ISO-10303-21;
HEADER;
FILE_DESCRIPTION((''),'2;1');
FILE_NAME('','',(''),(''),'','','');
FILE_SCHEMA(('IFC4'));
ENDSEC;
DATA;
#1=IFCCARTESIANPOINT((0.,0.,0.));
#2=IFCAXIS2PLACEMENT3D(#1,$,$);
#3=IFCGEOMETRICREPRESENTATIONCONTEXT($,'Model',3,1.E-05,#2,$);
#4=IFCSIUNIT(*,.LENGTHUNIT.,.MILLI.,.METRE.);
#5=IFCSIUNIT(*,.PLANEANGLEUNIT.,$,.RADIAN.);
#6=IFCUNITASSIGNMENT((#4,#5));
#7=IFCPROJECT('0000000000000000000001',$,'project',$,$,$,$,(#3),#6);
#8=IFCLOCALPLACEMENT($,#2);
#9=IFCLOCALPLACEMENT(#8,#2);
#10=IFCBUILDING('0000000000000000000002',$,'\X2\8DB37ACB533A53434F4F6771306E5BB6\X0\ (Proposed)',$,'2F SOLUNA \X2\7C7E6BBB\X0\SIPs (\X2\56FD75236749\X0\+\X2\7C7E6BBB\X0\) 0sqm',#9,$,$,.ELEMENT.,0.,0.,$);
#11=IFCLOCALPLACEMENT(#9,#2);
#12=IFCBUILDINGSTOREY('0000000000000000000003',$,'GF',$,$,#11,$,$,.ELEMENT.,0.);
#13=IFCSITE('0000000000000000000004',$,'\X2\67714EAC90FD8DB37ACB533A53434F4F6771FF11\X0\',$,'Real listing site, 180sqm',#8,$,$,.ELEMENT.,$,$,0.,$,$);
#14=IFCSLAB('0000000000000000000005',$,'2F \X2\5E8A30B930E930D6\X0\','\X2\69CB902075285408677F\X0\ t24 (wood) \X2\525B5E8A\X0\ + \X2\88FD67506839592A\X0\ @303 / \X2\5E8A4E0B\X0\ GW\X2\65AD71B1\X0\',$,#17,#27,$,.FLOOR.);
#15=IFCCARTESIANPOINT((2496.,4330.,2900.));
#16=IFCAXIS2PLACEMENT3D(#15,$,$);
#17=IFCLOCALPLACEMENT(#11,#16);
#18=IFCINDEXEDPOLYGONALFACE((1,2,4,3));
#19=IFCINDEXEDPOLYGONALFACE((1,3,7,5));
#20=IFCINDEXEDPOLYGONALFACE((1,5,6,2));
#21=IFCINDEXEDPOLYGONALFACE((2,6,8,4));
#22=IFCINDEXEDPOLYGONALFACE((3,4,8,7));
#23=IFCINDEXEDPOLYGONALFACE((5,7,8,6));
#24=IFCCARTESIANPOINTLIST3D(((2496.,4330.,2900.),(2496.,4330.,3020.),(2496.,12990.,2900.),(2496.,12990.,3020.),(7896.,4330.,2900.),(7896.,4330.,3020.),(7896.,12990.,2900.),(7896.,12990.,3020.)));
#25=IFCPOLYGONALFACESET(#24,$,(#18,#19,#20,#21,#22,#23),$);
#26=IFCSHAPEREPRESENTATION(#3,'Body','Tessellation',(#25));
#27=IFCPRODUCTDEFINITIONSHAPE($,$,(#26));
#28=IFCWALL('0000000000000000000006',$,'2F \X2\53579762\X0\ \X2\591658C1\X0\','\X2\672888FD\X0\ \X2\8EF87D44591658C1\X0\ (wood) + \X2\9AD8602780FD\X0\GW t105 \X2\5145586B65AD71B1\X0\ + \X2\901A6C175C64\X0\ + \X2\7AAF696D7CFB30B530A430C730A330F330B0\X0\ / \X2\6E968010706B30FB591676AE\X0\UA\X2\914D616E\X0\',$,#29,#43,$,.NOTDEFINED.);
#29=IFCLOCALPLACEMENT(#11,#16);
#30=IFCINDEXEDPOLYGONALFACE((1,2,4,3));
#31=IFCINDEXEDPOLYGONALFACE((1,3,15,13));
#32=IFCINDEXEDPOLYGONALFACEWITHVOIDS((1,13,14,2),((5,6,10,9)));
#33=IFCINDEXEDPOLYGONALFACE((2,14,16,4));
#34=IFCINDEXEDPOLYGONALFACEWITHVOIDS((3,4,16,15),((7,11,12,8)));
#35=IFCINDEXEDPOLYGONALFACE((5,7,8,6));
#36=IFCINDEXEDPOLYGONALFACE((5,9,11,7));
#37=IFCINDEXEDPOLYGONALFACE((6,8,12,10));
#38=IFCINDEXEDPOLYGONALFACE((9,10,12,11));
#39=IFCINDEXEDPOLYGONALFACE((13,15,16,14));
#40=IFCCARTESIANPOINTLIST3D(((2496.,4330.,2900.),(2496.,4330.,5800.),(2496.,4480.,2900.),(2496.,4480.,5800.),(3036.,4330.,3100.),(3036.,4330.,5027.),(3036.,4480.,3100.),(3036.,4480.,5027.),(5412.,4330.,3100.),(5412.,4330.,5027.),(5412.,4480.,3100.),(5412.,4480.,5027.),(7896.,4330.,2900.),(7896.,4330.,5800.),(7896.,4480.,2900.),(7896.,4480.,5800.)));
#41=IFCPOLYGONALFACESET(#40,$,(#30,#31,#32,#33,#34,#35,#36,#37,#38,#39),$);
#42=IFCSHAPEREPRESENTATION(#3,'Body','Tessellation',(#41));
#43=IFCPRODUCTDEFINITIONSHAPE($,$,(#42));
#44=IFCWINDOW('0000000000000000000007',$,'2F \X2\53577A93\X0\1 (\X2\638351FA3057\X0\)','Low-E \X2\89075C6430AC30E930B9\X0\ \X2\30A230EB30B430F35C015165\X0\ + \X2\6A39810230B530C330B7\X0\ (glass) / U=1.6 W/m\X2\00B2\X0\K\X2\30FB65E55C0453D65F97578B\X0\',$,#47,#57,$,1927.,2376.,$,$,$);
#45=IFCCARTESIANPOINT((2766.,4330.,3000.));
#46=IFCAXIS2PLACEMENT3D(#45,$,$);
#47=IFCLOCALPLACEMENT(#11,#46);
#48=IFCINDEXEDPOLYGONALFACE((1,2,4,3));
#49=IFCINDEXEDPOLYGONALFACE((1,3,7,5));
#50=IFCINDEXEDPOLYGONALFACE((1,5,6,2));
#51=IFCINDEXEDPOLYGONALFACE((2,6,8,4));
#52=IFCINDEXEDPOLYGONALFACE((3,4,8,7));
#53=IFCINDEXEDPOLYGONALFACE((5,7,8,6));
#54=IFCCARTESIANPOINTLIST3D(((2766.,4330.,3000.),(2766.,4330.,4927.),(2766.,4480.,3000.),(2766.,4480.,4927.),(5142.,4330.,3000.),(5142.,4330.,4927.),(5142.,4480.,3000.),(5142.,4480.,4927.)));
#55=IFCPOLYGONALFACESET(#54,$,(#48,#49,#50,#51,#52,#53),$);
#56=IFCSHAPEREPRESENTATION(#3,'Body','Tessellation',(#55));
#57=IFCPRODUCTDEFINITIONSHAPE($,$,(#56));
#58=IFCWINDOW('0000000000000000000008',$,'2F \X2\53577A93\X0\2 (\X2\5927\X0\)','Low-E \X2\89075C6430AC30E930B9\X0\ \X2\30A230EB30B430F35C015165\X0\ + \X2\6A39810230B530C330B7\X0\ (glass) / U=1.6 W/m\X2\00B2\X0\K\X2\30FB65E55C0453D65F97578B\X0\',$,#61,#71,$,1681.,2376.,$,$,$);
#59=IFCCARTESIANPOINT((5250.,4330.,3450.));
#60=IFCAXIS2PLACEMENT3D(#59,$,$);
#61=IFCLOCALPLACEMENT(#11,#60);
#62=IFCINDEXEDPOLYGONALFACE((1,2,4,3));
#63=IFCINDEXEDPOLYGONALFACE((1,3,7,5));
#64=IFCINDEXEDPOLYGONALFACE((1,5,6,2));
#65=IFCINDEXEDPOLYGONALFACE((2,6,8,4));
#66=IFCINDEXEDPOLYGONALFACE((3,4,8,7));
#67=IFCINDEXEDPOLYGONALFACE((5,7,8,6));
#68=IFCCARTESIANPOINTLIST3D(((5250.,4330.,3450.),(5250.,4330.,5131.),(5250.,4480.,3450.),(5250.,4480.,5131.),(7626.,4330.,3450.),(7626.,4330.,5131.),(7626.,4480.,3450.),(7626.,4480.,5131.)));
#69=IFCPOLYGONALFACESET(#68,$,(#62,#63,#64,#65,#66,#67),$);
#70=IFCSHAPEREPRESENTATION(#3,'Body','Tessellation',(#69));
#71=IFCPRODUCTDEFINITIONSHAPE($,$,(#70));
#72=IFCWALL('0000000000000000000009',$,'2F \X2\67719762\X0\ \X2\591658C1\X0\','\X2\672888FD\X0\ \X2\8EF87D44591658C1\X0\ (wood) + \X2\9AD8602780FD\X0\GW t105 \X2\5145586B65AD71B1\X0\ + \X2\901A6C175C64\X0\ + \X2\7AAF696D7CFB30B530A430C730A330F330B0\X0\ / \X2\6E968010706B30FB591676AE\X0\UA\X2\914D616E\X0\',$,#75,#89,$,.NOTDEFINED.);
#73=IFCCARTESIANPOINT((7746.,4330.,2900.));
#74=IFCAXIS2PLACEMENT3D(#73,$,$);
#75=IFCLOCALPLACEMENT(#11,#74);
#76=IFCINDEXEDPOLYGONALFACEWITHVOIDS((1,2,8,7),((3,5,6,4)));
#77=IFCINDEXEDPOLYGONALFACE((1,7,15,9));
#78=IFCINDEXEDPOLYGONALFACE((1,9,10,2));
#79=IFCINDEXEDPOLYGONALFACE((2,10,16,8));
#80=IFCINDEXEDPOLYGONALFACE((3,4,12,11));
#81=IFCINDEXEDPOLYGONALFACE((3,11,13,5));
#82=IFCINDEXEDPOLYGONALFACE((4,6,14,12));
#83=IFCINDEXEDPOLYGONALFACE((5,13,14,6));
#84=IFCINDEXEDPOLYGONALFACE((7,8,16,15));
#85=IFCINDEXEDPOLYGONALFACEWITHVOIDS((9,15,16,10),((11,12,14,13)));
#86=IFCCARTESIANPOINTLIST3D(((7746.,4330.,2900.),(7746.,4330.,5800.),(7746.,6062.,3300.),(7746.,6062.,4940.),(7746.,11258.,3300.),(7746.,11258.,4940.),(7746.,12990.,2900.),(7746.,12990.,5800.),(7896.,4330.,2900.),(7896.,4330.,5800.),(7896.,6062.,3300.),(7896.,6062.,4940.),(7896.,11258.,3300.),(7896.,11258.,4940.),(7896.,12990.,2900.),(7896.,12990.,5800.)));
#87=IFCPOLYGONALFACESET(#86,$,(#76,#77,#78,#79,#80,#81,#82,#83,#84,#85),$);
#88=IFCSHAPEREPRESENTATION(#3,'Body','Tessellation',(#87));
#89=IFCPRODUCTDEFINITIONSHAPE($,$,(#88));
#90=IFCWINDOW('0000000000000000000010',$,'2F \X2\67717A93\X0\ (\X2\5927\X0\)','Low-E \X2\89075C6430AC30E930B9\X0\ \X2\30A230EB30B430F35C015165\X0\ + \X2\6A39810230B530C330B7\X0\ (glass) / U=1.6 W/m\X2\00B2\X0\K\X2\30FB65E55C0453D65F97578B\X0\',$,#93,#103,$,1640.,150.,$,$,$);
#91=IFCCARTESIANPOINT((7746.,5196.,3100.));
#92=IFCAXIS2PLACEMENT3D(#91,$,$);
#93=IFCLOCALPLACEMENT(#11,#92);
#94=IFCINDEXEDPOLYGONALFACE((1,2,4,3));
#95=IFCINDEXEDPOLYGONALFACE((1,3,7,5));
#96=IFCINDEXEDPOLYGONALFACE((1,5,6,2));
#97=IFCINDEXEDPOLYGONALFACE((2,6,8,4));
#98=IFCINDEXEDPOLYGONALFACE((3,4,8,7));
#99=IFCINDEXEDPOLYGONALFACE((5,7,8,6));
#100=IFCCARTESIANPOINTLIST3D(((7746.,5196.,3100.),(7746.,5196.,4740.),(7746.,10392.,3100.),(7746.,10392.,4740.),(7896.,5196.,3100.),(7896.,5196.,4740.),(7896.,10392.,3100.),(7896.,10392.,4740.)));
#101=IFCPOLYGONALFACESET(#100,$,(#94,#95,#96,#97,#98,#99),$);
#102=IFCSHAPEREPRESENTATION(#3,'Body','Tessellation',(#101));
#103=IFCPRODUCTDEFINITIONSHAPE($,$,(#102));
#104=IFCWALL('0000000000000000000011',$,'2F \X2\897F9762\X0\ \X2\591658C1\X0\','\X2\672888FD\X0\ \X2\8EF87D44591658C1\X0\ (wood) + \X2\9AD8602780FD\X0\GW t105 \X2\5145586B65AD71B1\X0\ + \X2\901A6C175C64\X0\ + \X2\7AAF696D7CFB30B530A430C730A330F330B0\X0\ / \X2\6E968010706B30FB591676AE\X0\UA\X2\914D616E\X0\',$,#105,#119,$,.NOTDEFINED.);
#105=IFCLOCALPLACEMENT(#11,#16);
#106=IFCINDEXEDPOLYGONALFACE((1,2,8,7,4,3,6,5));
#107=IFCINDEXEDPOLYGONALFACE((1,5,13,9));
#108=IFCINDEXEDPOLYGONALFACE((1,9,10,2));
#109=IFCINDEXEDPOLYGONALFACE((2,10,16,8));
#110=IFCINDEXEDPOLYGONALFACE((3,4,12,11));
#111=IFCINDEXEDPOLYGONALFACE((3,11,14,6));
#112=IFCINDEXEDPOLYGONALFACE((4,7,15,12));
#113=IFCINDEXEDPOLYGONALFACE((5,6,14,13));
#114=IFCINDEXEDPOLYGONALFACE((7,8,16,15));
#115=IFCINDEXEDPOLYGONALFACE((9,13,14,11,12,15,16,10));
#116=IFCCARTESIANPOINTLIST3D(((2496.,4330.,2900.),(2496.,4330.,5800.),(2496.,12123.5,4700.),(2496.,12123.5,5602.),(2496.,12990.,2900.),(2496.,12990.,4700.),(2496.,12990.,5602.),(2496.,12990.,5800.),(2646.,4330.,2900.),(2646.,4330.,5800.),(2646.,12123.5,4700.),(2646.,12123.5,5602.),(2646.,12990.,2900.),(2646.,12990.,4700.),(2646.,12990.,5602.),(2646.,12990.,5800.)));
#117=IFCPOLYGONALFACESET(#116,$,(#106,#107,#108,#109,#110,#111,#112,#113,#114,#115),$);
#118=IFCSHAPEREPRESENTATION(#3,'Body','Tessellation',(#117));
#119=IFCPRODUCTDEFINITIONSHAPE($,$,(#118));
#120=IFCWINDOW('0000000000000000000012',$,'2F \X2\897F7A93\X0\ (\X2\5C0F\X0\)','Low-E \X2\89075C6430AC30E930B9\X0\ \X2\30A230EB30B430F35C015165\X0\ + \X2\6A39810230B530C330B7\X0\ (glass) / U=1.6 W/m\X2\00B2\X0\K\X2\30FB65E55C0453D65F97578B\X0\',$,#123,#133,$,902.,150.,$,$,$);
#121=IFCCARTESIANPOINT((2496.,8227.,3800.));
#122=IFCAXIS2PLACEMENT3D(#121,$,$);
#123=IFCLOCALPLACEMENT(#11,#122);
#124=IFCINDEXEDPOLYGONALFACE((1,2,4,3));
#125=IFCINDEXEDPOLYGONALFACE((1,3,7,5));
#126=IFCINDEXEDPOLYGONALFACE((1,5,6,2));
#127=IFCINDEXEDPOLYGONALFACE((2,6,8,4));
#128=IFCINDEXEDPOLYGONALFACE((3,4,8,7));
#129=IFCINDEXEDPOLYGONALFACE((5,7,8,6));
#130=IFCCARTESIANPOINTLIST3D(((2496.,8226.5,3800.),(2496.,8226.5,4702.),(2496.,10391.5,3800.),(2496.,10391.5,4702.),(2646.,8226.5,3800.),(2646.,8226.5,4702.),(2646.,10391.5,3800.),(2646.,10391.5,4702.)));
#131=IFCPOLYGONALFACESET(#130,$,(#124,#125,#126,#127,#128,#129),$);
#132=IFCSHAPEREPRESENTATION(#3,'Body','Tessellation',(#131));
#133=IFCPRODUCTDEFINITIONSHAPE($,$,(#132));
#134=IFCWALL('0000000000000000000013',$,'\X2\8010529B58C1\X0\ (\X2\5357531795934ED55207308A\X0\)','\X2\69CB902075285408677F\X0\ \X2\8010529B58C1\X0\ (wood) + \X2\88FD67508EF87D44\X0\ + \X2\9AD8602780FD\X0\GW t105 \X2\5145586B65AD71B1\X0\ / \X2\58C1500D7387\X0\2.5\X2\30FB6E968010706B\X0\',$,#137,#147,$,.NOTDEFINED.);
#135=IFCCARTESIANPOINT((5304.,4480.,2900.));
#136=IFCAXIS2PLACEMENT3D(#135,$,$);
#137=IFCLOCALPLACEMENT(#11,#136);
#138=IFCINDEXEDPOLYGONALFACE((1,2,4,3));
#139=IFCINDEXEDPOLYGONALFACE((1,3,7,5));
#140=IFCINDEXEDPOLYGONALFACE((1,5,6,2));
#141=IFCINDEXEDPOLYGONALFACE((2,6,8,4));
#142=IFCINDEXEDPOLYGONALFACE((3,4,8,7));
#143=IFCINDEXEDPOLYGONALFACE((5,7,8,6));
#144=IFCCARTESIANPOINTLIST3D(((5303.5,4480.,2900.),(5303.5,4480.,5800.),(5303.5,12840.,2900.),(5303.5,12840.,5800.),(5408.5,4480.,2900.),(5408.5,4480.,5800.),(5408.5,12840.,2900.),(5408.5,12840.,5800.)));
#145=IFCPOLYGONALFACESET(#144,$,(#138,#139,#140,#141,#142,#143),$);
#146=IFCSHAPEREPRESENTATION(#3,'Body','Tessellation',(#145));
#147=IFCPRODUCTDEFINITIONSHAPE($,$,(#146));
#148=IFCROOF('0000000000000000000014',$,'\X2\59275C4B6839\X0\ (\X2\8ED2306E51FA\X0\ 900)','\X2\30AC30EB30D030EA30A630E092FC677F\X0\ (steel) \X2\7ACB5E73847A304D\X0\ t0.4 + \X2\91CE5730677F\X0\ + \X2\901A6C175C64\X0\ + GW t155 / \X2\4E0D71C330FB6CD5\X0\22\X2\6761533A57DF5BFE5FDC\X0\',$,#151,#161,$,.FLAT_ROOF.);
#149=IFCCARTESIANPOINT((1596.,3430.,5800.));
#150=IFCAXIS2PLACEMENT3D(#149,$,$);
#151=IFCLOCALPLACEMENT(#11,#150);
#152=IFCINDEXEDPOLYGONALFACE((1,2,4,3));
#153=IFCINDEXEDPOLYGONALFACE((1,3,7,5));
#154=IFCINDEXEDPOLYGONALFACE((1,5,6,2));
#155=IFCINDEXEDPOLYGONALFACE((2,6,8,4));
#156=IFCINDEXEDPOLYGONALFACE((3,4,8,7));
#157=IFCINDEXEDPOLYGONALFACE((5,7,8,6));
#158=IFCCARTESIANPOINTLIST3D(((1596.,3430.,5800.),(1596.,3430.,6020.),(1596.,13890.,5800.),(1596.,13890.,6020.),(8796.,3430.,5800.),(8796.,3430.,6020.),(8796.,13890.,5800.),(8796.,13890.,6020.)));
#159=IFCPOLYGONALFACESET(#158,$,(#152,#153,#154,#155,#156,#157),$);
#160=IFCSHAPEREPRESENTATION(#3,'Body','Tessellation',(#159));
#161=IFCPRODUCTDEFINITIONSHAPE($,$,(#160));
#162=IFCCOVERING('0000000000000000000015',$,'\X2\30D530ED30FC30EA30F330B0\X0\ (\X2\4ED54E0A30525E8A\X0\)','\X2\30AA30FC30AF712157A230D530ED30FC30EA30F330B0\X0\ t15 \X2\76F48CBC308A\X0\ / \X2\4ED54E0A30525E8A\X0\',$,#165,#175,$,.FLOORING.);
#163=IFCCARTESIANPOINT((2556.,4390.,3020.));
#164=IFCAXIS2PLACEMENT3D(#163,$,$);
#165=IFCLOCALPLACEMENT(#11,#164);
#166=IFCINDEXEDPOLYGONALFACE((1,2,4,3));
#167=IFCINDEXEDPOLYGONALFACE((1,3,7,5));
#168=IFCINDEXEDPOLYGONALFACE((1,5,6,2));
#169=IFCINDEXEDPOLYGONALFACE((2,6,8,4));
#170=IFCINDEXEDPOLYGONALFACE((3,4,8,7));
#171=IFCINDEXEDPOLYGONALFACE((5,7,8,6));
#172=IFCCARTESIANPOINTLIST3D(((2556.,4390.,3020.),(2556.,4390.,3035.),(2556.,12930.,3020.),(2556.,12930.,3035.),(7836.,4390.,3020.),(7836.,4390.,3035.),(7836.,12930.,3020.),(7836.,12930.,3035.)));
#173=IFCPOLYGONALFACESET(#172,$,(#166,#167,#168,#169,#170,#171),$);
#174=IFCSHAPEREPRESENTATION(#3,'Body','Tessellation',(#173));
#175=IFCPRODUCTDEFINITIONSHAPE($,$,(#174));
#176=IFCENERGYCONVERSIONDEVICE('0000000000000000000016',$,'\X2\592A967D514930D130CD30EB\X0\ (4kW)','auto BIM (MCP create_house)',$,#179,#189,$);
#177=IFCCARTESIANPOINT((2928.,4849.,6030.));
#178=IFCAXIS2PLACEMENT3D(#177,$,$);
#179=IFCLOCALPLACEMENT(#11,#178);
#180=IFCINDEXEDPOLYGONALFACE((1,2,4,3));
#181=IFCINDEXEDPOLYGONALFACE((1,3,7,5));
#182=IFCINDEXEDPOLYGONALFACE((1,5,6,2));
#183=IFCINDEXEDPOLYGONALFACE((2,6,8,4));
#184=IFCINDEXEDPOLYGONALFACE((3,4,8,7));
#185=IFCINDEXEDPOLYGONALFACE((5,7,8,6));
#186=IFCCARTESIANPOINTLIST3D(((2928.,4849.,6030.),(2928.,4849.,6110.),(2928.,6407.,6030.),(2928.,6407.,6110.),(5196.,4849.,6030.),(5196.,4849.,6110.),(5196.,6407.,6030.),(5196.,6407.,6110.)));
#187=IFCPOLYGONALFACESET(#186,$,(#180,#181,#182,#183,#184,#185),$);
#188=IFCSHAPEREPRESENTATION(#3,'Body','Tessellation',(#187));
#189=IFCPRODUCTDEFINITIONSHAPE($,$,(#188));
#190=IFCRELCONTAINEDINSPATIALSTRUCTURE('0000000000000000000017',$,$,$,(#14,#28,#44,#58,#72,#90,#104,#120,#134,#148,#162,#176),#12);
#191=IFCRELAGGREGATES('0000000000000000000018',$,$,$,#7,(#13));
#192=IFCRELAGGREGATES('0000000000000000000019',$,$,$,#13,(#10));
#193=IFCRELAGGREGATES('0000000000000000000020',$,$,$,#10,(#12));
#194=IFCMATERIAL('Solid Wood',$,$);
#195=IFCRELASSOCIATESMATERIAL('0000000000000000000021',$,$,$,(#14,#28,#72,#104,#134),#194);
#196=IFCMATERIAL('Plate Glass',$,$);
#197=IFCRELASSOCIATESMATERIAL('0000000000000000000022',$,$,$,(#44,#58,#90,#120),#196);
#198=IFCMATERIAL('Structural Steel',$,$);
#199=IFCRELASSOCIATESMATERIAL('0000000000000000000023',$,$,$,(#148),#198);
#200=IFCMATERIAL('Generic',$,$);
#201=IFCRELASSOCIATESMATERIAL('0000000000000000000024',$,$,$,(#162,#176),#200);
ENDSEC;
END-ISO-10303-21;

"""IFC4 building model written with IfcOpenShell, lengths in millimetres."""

from ifc_helpers import new_model, si_unit, frame, frame_2d, origin, place, context, project, spatial, rectangle, extrude, material, element, fill, save


model = new_model("IFC4")

# Units and contexts
model_context = context("Model", 3, precision=1e-05, world=origin())
ifc_project = project(units=[si_unit("LENGTHUNIT", "METRE", prefix="MILLI"), si_unit("PLANEANGLEUNIT", "RADIAN")], contexts=[model_context])

# Site, building, storey
site_placement = place(None, origin())
site = spatial("IfcSite", under=ifc_project, at=site_placement, Name="東京都足立区千住東１", ObjectType="Real listing site, 180sqm", CompositionType="ELEMENT", RefElevation=0.0)
building_placement = place(site_placement, origin())
building = spatial("IfcBuilding", under=site, at=building_placement, Name="足立区千住東の家 (Proposed)", ObjectType="2F SOLUNA 籾殻SIPs (国産杉+籾殻) 0sqm", CompositionType="ELEMENT", ElevationOfRefHeight=0.0, ElevationOfTerrain=0.0)
storey_placement = place(building_placement, origin())
storey = spatial("IfcBuildingStorey", under=building, at=storey_placement, Name="GF", CompositionType="ELEMENT", Elevation=0.0)

# Slab
ifc_material_1 = material(Name="Solid Wood")
slab_placement = place(storey_placement, frame((2496.0, 4330.0, 2900.0)))
element("IfcSlab", 1, at=slab_placement, inside=storey, material=ifc_material_1, Name="2F 床スラブ", Description="構造用合板 t24 (wood) 剛床 + 製材根太 @303 / 床下 GW断熱", PredefinedType="FLOOR", context=model_context, shape_type="SweptSolid", body=[
    extrude(rectangle(XDim=5400.0, YDim=8660.0, at=frame_2d((2700.0, 4330.0))), frame((2496.0, 4330.0, 2900.0)), (0.0, 0.0, 1.0), 120.0),
])

# Wall, openings, windows
wall_1_placement = place(storey_placement, frame((2496.0, 4330.0, 2900.0)))
wall_1 = element("IfcWall", 2, at=wall_1_placement, inside=storey, material=ifc_material_1, Name="2F 南面 外壁", Description="木製 軸組外壁 (wood) + 高性能GW t105 充填断熱 + 通気層 + 窯業系サイディング / 準耐火・外皮UA配慮", PredefinedType="NOTDEFINED", context=model_context, shape_type="SweptSolid", body=[
    extrude(rectangle(XDim=5400.0, YDim=150.0, at=frame_2d((2700.0, 75.0))), frame((2496.0, 4330.0, 2900.0)), (0.0, 0.0, 1.0), 2900.0),
])
opening_1_placement = place(storey_placement, frame((2766.0, 4330.0, 3000.0)))
opening_1 = element("IfcOpeningElement", 3, at=opening_1_placement, cuts=wall_1, PredefinedType="NOTDEFINED", context=model_context, shape_type="SweptSolid", body=[
    extrude(rectangle(XDim=2376.0, YDim=150.0, at=frame_2d((1188.0, 75.0))), frame((2766.0, 4330.0, 3000.0)), (0.0, 0.0, 1.0), 1927.0),
])
opening_2_placement = place(storey_placement, frame((5250.0, 4330.0, 3450.0)))
opening_2 = element("IfcOpeningElement", 4, at=opening_2_placement, cuts=wall_1, PredefinedType="NOTDEFINED", context=model_context, shape_type="SweptSolid", body=[
    extrude(rectangle(XDim=2376.0, YDim=150.0, at=frame_2d((1188.0, 75.0))), frame((5250.0, 4330.0, 3450.0)), (0.0, 0.0, 1.0), 1681.0),
])
ifc_material_2 = material(Name="Plate Glass")
window_1_placement = place(storey_placement, frame((2766.0, 4330.0, 3000.0)))
window_1 = element("IfcWindow", 5, at=window_1_placement, inside=storey, material=ifc_material_2, Name="2F 南窓1 (掃出し)", Description="Low-E 複層ガラス アルゴン封入 + 樹脂サッシ (glass) / U=1.6 W/m²K・日射取得型", OverallHeight=1927.0, OverallWidth=2376.0, context=model_context, shape_type="SweptSolid", body=[
    extrude(rectangle(XDim=2376.0, YDim=150.0, at=frame_2d((1188.0, 75.0))), frame((2766.0, 4330.0, 3000.0)), (0.0, 0.0, 1.0), 1927.0),
])
fill(opening_1, window_1)
window_2_placement = place(storey_placement, frame((5250.0, 4330.0, 3450.0)))
window_2 = element("IfcWindow", 6, at=window_2_placement, inside=storey, material=ifc_material_2, Name="2F 南窓2 (大)", Description="Low-E 複層ガラス アルゴン封入 + 樹脂サッシ (glass) / U=1.6 W/m²K・日射取得型", OverallHeight=1681.0, OverallWidth=2376.0, context=model_context, shape_type="SweptSolid", body=[
    extrude(rectangle(XDim=2376.0, YDim=150.0, at=frame_2d((1188.0, 75.0))), frame((5250.0, 4330.0, 3450.0)), (0.0, 0.0, 1.0), 1681.0),
])
fill(opening_2, window_2)

# Walls, openings, windows
wall_2_placement = place(storey_placement, frame((7746.0, 4330.0, 2900.0)))
wall_2 = element("IfcWall", 7, at=wall_2_placement, inside=storey, material=ifc_material_1, Name="2F 東面 外壁", Description="木製 軸組外壁 (wood) + 高性能GW t105 充填断熱 + 通気層 + 窯業系サイディング / 準耐火・外皮UA配慮", PredefinedType="NOTDEFINED", context=model_context, shape_type="SweptSolid", body=[
    extrude(rectangle(XDim=150.0, YDim=8660.0, at=frame_2d((75.0, 4330.0))), frame((7746.0, 4330.0, 2900.0)), (0.0, 0.0, 1.0), 2900.0),
])
opening_3_placement = place(storey_placement, frame((7746.0, 5196.0, 3100.0)))
opening_3 = element("IfcOpeningElement", 8, at=opening_3_placement, cuts=wall_2, PredefinedType="NOTDEFINED", context=model_context, shape_type="SweptSolid", body=[
    extrude(rectangle(XDim=150.0, YDim=5196.0, at=frame_2d((75.0, 2598.0))), frame((7746.0, 5196.0, 3100.0)), (0.0, 0.0, 1.0), 1640.0),
])
window_3_placement = place(storey_placement, frame((7746.0, 5196.0, 3100.0)))
window_3 = element("IfcWindow", 9, at=window_3_placement, inside=storey, material=ifc_material_2, Name="2F 東窓 (大)", Description="Low-E 複層ガラス アルゴン封入 + 樹脂サッシ (glass) / U=1.6 W/m²K・日射取得型", OverallHeight=1640.0, OverallWidth=150.0, context=model_context, shape_type="SweptSolid", body=[
    extrude(rectangle(XDim=150.0, YDim=5196.0, at=frame_2d((75.0, 2598.0))), frame((7746.0, 5196.0, 3100.0)), (0.0, 0.0, 1.0), 1640.0),
])
fill(opening_3, window_3)
wall_3_placement = place(storey_placement, frame((2496.0, 4330.0, 2900.0)))
wall_3 = element("IfcWall", 10, at=wall_3_placement, inside=storey, material=ifc_material_1, Name="2F 西面 外壁", Description="木製 軸組外壁 (wood) + 高性能GW t105 充填断熱 + 通気層 + 窯業系サイディング / 準耐火・外皮UA配慮", PredefinedType="NOTDEFINED", context=model_context, shape_type="SweptSolid", body=[
    extrude(rectangle(XDim=150.0, YDim=8660.0, at=frame_2d((75.0, 4330.0))), frame((2496.0, 4330.0, 2900.0)), (0.0, 0.0, 1.0), 2900.0),
])
opening_4_placement = place(storey_placement, frame((2496.0, 8227.0, 3800.0)))
opening_4 = element("IfcOpeningElement", 11, at=opening_4_placement, cuts=wall_3, PredefinedType="NOTDEFINED", context=model_context, shape_type="SweptSolid", body=[
    extrude(rectangle(XDim=150.0, YDim=2165.0, at=frame_2d((75.0, 1082.0))), frame((2496.0, 8227.0, 3800.0)), (0.0, 0.0, 1.0), 902.0),
])
window_4_placement = place(storey_placement, frame((2496.0, 8227.0, 3800.0)))
window_4 = element("IfcWindow", 12, at=window_4_placement, inside=storey, material=ifc_material_2, Name="2F 西窓 (小)", Description="Low-E 複層ガラス アルゴン封入 + 樹脂サッシ (glass) / U=1.6 W/m²K・日射取得型", OverallHeight=902.0, OverallWidth=150.0, context=model_context, shape_type="SweptSolid", body=[
    extrude(rectangle(XDim=150.0, YDim=2165.0, at=frame_2d((75.0, 1082.0))), frame((2496.0, 8227.0, 3800.0)), (0.0, 0.0, 1.0), 902.0),
])
fill(opening_4, window_4)

# Wall
wall_4_placement = place(storey_placement, frame((5304.0, 4480.0, 2900.0)))
element("IfcWall", 13, at=wall_4_placement, inside=storey, material=ifc_material_1, Name="耐力壁 (南北間仕切り)", Description="構造用合板 耐力壁 (wood) + 製材軸組 + 高性能GW t105 充填断熱 / 壁倍率2.5・準耐火", PredefinedType="NOTDEFINED", context=model_context, shape_type="SweptSolid", body=[
    extrude(rectangle(XDim=105.0, YDim=8360.0, at=frame_2d((52.0, 4180.0))), frame((5304.0, 4480.0, 2900.0)), (0.0, 0.0, 1.0), 2900.0),
])

# Roof
ifc_material_3 = material(Name="Structural Steel")
roof_placement = place(storey_placement, frame((1596.0, 3430.0, 5800.0)))
element("IfcRoof", 14, at=roof_placement, inside=storey, material=ifc_material_3, Name="大屋根 (軒の出 900)", Description="ガルバリウム鋼板 (steel) 立平葺き t0.4 + 野地板 + 通気層 + GW t155 / 不燃・法22条区域対応", PredefinedType="FLAT_ROOF", context=model_context, shape_type="SweptSolid", body=[
    extrude(rectangle(XDim=7200.0, YDim=10460.0, at=frame_2d((3600.0, 5230.0))), frame((1596.0, 3430.0, 5800.0)), (0.0, 0.0, 1.0), 220.0),
])

# Covering
ifc_material_4 = material(Name="Generic")
covering_placement = place(storey_placement, frame((2556.0, 4390.0, 3020.0)))
element("IfcCovering", 15, at=covering_placement, inside=storey, material=ifc_material_4, Name="フローリング (仕上げ床)", Description="オーク無垢フローリング t15 直貼り / 仕上げ床", PredefinedType="FLOORING", context=model_context, shape_type="SweptSolid", body=[
    extrude(rectangle(XDim=5280.0, YDim=8540.0, at=frame_2d((2640.0, 4270.0))), frame((2556.0, 4390.0, 3020.0)), (0.0, 0.0, 1.0), 15.0),
])

# Energy conversion device
energy_conversion_device_placement = place(storey_placement, frame((2928.0, 4849.0, 6030.0)))
element("IfcEnergyConversionDevice", 16, at=energy_conversion_device_placement, inside=storey, material=ifc_material_4, Name="太陽光パネル (4kW)", Description="auto BIM (MCP create_house)", context=model_context, shape_type="SweptSolid", body=[
    extrude(rectangle(XDim=2268.0, YDim=1558.0, at=frame_2d((1134.0, 779.0))), frame((2928.0, 4849.0, 6030.0)), (0.0, 0.0, 1.0), 80.0),
])

save(model, "model.ifc")
